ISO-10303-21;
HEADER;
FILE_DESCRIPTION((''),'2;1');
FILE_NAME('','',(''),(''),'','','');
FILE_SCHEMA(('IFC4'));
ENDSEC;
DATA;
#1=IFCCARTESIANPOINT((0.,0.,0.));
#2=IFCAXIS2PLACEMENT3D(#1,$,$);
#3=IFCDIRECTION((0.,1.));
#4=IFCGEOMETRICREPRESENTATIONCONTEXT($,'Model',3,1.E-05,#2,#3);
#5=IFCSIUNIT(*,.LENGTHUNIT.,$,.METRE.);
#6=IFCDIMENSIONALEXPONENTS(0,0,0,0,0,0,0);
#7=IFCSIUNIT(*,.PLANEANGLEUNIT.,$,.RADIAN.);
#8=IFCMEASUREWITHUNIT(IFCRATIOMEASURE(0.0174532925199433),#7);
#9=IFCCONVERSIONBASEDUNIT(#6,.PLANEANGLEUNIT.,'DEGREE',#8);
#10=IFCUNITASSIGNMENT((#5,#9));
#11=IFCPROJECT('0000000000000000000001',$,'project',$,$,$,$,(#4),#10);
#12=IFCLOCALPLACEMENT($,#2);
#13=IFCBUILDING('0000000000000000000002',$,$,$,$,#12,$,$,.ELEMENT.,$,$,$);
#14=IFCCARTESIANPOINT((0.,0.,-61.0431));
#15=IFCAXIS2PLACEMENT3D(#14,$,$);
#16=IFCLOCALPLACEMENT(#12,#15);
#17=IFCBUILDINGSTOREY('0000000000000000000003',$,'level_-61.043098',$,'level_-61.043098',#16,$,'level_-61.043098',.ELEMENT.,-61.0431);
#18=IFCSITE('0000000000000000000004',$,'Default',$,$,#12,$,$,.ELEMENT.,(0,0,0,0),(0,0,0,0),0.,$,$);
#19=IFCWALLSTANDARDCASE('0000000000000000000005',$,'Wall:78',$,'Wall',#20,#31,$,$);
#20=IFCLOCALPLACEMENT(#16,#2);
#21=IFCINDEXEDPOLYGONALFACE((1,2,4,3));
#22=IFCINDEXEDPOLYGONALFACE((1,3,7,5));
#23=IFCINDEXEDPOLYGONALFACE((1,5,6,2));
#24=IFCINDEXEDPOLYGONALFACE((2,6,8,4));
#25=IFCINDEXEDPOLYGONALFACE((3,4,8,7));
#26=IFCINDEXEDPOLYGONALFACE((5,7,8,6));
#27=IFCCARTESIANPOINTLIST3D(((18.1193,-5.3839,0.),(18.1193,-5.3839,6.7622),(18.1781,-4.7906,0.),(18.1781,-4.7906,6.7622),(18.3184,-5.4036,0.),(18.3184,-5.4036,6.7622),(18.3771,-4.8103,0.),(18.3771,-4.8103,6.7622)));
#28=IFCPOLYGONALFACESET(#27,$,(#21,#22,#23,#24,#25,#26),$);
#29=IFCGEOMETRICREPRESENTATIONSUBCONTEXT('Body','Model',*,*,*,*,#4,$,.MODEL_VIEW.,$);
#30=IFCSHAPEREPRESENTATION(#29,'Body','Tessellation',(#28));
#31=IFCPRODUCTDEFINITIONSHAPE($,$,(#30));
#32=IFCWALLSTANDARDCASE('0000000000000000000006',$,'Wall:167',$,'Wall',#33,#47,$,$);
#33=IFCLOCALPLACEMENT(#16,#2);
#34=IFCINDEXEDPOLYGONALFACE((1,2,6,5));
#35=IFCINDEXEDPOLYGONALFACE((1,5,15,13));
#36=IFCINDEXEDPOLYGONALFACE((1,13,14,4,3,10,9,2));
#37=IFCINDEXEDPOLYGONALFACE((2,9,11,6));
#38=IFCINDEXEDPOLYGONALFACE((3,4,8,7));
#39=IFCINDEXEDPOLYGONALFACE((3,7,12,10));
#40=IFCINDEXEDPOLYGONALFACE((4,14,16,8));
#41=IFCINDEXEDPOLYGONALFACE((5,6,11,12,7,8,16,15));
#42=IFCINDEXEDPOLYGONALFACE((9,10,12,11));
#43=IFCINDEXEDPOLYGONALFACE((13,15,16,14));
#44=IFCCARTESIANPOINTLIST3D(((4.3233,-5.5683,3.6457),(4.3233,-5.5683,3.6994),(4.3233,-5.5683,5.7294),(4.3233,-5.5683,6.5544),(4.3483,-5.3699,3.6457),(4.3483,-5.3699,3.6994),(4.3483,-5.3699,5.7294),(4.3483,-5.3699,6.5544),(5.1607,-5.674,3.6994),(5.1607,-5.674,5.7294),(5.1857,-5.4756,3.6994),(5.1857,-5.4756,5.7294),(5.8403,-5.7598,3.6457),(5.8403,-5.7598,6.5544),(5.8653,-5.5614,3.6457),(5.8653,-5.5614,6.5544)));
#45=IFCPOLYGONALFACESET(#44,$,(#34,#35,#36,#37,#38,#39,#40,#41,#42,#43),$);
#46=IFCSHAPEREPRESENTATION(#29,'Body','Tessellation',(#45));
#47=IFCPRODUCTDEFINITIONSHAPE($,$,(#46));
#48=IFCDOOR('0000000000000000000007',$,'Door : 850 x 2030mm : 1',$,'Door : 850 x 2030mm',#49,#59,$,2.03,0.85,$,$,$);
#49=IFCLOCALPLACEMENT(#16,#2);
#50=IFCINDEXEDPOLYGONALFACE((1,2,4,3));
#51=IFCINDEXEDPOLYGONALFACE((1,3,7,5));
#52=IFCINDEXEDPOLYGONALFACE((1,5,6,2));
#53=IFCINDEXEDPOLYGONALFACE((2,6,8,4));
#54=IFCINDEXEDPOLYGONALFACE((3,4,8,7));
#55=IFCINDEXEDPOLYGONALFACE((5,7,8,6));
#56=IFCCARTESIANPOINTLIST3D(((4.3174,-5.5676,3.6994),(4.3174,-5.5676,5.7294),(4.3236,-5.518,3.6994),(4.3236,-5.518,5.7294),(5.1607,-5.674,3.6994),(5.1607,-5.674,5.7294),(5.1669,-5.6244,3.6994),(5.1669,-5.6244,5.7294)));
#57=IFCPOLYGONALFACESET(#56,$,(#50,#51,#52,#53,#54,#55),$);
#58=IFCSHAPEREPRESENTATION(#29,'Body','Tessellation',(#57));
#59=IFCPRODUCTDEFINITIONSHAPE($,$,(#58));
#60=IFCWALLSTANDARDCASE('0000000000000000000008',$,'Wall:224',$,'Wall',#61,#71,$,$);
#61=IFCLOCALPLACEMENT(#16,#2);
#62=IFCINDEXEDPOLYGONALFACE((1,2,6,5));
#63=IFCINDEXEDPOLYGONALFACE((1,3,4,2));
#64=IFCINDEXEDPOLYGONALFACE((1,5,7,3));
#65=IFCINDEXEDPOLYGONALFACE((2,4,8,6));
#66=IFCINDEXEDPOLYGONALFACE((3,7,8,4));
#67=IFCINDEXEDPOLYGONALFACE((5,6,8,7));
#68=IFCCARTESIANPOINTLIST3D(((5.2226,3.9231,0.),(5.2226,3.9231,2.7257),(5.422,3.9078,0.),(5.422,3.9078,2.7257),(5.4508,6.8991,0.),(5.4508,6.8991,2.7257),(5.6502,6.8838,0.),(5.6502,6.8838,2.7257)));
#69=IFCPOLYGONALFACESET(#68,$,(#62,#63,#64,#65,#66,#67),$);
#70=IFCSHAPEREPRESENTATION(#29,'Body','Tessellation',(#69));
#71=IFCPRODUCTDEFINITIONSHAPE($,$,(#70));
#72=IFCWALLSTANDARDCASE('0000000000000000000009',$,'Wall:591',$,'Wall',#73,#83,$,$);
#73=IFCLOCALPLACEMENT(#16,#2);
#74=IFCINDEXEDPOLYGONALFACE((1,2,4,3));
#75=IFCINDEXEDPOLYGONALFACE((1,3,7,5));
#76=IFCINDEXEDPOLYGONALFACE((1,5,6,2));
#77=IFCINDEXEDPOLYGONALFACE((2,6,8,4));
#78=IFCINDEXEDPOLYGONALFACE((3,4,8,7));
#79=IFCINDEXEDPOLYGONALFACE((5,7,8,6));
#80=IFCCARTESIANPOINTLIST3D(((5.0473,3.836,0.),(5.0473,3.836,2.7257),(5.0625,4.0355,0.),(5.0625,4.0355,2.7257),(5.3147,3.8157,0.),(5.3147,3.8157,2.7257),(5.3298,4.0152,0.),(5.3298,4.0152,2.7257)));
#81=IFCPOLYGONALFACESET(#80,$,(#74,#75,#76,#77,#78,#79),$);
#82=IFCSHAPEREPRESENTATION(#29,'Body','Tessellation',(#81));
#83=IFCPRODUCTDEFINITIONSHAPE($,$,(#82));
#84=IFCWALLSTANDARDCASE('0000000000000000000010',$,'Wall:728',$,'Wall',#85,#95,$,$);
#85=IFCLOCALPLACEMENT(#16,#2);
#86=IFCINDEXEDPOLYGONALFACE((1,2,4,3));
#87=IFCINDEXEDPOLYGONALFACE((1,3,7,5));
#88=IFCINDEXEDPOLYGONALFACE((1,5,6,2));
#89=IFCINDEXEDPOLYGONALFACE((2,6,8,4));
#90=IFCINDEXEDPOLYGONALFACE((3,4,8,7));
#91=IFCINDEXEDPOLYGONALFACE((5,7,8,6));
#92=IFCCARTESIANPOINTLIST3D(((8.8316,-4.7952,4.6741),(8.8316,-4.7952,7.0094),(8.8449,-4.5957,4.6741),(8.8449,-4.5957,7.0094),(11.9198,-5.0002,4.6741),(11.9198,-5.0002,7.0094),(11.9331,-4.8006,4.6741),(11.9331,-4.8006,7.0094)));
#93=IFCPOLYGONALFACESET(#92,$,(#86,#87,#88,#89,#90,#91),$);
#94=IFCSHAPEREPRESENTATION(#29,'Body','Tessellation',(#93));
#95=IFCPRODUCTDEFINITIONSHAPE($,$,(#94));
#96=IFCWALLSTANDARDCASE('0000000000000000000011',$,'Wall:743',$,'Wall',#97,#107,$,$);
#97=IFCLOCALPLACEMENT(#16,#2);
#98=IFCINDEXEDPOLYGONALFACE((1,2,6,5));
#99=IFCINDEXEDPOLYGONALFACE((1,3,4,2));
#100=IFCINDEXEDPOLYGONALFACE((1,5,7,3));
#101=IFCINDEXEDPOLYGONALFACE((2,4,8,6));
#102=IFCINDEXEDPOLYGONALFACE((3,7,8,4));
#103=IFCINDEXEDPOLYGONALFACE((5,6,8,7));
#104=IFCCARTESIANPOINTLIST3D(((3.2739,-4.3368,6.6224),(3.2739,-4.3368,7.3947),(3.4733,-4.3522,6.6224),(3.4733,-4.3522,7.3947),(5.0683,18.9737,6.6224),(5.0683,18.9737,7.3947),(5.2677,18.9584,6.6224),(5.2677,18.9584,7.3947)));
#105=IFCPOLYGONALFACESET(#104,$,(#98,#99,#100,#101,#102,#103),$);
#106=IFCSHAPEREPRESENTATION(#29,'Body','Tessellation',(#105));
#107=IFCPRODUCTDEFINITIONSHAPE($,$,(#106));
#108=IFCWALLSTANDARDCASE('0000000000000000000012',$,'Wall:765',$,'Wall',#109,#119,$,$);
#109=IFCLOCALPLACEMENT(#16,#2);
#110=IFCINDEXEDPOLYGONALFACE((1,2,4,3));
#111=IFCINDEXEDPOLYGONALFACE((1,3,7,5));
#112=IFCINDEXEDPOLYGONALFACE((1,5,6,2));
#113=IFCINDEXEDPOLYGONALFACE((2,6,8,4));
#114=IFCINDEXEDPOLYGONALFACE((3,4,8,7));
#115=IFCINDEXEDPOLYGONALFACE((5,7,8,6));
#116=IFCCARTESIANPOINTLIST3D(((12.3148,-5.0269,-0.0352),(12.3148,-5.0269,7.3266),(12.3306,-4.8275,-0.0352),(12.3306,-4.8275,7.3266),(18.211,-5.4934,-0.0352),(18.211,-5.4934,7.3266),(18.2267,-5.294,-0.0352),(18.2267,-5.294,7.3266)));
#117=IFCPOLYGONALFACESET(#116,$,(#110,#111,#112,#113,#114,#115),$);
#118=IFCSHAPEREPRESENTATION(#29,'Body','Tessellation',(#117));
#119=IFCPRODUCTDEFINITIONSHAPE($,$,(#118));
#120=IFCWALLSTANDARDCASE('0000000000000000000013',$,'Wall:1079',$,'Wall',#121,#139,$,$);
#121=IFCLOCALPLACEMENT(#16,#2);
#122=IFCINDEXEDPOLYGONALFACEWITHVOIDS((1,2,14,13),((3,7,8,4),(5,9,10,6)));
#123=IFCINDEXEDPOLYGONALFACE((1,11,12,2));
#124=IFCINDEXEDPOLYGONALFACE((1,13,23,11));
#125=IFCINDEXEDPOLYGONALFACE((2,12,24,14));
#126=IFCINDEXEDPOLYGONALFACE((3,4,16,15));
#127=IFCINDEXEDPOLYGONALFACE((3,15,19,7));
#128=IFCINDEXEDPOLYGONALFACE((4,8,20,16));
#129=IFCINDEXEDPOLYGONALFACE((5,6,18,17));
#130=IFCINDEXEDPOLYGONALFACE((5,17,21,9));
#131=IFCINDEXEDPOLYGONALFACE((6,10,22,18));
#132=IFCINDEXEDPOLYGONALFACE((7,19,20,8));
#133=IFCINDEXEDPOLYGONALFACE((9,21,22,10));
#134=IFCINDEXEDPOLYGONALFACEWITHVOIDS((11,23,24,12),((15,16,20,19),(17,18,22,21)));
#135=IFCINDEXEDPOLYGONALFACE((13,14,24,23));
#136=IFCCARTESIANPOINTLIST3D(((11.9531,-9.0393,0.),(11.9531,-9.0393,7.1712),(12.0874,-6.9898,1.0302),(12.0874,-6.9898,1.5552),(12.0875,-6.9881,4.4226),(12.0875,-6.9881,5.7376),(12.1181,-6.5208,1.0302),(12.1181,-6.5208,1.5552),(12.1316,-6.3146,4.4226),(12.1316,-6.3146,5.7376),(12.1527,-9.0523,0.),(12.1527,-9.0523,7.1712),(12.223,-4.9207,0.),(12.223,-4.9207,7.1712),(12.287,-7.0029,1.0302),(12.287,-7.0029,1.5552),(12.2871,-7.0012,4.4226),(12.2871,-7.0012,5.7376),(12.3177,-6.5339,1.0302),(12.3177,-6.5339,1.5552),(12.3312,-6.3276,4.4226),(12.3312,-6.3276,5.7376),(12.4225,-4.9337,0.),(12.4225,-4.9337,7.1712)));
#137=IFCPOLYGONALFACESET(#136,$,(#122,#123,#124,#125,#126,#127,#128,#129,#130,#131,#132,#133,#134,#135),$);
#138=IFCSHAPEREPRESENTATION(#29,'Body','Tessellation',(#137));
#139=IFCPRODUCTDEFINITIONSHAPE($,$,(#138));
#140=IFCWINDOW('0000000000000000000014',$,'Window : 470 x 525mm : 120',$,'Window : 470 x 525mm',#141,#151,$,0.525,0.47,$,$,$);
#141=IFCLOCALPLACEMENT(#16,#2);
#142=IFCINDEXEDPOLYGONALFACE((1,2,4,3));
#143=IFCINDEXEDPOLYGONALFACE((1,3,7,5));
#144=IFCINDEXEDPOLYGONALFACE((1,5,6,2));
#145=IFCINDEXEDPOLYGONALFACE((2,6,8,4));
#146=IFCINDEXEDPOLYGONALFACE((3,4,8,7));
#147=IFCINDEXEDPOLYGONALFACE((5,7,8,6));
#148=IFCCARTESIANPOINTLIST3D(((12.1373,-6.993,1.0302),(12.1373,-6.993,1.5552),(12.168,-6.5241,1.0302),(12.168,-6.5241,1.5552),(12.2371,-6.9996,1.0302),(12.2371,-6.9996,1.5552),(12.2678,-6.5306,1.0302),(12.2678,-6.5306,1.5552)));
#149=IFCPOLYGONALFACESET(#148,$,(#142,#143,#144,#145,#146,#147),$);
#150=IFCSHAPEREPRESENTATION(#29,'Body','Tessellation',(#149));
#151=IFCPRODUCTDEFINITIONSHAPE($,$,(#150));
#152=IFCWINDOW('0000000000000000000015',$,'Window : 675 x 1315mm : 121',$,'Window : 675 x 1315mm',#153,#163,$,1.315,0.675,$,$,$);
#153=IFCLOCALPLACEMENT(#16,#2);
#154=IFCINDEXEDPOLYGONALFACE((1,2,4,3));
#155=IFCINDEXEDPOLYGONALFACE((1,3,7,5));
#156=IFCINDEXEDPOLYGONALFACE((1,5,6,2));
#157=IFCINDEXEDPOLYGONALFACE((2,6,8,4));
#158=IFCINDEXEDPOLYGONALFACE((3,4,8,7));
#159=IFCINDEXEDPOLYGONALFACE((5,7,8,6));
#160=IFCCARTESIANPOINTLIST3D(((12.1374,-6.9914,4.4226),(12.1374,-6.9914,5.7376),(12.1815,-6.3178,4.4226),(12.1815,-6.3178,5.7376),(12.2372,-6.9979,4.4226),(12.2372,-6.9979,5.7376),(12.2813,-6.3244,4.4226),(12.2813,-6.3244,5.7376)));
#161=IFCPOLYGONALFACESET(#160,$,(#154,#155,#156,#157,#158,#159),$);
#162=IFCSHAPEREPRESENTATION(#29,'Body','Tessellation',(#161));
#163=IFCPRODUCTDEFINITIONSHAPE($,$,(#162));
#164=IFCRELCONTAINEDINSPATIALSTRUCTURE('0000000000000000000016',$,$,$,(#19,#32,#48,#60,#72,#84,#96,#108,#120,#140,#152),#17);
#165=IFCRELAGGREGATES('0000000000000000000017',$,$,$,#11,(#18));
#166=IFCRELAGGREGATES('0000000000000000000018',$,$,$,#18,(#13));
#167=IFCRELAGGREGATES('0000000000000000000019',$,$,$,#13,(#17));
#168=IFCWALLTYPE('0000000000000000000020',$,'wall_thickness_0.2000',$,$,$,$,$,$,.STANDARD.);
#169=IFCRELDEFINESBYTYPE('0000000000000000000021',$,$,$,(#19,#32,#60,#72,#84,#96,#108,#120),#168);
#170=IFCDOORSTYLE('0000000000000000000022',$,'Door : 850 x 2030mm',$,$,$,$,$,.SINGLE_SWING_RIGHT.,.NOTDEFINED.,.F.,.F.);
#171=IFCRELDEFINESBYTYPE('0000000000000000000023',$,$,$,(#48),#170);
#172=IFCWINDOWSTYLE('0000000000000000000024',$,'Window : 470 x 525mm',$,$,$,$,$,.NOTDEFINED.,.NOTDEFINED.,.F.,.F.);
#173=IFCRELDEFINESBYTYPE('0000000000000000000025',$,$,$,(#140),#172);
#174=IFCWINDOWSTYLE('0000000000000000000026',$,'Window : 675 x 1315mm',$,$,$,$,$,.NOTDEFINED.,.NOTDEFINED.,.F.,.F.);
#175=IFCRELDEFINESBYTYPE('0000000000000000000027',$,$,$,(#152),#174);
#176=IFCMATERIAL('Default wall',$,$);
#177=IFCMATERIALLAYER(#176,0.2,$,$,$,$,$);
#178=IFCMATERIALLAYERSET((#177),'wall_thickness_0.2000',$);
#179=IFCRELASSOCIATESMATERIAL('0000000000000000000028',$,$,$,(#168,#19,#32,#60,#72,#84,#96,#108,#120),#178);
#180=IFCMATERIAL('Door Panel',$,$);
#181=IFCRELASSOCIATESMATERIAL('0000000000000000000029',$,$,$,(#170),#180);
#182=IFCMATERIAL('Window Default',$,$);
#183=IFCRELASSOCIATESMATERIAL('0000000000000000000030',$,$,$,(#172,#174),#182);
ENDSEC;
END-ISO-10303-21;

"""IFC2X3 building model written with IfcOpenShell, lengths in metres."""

from ifc_helpers import new_model, entity, si_unit, converted_unit, direction, frame, frame_2d, origin, origin_2d_with_axis, place, context, subcontext, project, spatial, polyline, rectangle, outline, extrude, source, transform, mapped, material, layer, layer_set, layer_usage, type_object, type_shapes, element, fill, save


model = new_model("IFC2X3")

# Units and contexts
model_context = context("Model", 3, precision=1e-05, world=origin(), true_north=direction((0.0, 1.0)))
body_context = subcontext(model_context, "Body", "Model", "MODEL_VIEW")
ifc_project = project(units=[si_unit("LENGTHUNIT", "METRE"), converted_unit("PLANEANGLEUNIT", "DEGREE", entity("IfcRatioMeasure", 0.0174532925199433), si_unit("PLANEANGLEUNIT", "RADIAN"), dimensions=[0, 0, 0, 0, 0, 0, 0])], contexts=[model_context])

# Site, building, storey
placement_1 = place(None, origin())
site = spatial("IfcSite", under=ifc_project, at=placement_1, Name="Default", CompositionType="ELEMENT", RefLatitude=(0, 0, 0, 0), RefLongitude=(0, 0, 0, 0), RefElevation=0.0)
building = spatial("IfcBuilding", under=site, at=placement_1, CompositionType="ELEMENT")
storey_placement = place(placement_1, frame((0.0, 0.0, -61.0431)))
storey = spatial("IfcBuildingStorey", under=building, at=storey_placement, Name="level_-61.043098", ObjectType="level_-61.043098", LongName="level_-61.043098", CompositionType="ELEMENT", Elevation=-61.0431)

# Wall
ifc_material_1 = material(Name="Default wall")
ifc_layer = layer(ifc_material_1, 0.2)
ifc_layer_set = layer_set([ifc_layer], Name="wall_thickness_0.2000")
ifc_layer_usage = layer_usage(ifc_layer_set, "AXIS2", "POSITIVE", -0.1)
wall_type = type_object("IfcWallType", Name="wall_thickness_0.2000", PredefinedType="STANDARD", material=ifc_layer_set)
wall_1_placement = place(storey_placement, frame((18.2189, -5.3937, 0.0), z_axis=(0.0, 0.0, 1.0), x_axis=(0.098503, 0.995137, 0.0)))
element("IfcWallStandardCase", 1, at=wall_1_placement, inside=storey, type_object=wall_type, material=ifc_layer_usage, Name="Wall:78", ObjectType="Wall", context=body_context, shape_type="SweptSolid", body=[
    extrude(outline(polyline([(0.5961, -0.1), (0.5961, 0.1), (0.0, 0.1), (0.0, -0.1), (0.5961, -0.1)])), origin(), (0.0, 0.0, 1.0), 6.7622),
])

# Wall, opening, door
placement_2 = place(placement_1, frame((0.0, 0.0, -57.3974)))
wall_2_placement = place(placement_2, frame((5.8528, -5.6606, 0.0), z_axis=(0.0, 0.0, 1.0), x_axis=(-0.992132, 0.125199, 0.0)))
wall_2 = element("IfcWallStandardCase", 2, at=wall_2_placement, inside=storey, type_object=wall_type, material=ifc_layer_usage, Name="Wall:167", ObjectType="Wall", context=body_context, shape_type="SweptSolid", body=[
    extrude(outline(polyline([(1.529, -0.1), (1.529, 0.1), (0.0, 0.1), (0.0, -0.1), (1.529, -0.1)])), origin(), (0.0, 0.0, 1.0), 2.9087),
])
opening_1_placement = place(wall_2_placement, frame((0.685, -0.1, 0.0537)))
opening_1 = element("IfcOpeningElement", 3, at=opening_1_placement, cuts=wall_2, ObjectType="Opening", context=body_context, shape_type="SweptSolid", body=[
    extrude(rectangle(XDim=0.85, YDim=2.03, at=frame_2d((1.015, 0.425), x_axis=(0.0, 1.0))), frame((0.0, 0.0, 0.0), z_axis=(0.0, 1.0, 0.0), x_axis=(0.0, 0.0, 1.0)), (0.0, 0.0, 1.0), 0.2),
])
ifc_material_2 = material(Name="Door Panel")
door_style = type_object("IfcDoorStyle", Name="Door : 850 x 2030mm", ConstructionType="NOTDEFINED", OperationType="SINGLE_SWING_RIGHT", ParameterTakesPrecedence=False, Sizeable=False, material=ifc_material_2)
shared_shape_1 = source(origin(), body_context, "Body", "SweptSolid", [
    extrude(rectangle(XDim=0.05, YDim=0.85, at=origin_2d_with_axis()), frame((0.425, 0.175, 0.0), z_axis=(0.0, 0.0, 1.0), x_axis=(0.0, 1.0, 0.0)), (0.0, 0.0, 1.0), 2.03),
])
type_shapes(door_style, [shared_shape_1])
door_placement = place(opening_1_placement, origin())
door = element("IfcDoor", 4, at=door_placement, inside=storey, type_object=door_style, Name="Door : 850 x 2030mm : 1", ObjectType="Door : 850 x 2030mm", OverallHeight=2.03, OverallWidth=0.85, context=body_context, shape_type="MappedRepresentation", body=[
    mapped(shared_shape_1, transform((0.0, 0.0, 0.0), scale=1.0)),
])
fill(opening_1, door)

# Walls
wall_3_placement = place(storey_placement, frame((5.5505, 6.8915, 0.0), z_axis=(0.0, 0.0, 1.0), x_axis=(-0.076474, -0.997072, 0.0)))
element("IfcWallStandardCase", 5, at=wall_3_placement, inside=storey, type_object=wall_type, material=ifc_layer_usage, Name="Wall:224", ObjectType="Wall", context=body_context, shape_type="SweptSolid", body=[
    extrude(outline(polyline([(2.9847, -0.1), (2.9847, 0.1), (0.0, 0.1), (0.0, -0.1), (2.9847, -0.1)])), origin(), (0.0, 0.0, 1.0), 2.7257),
])
wall_4_placement = place(storey_placement, frame((5.3223, 3.9154, 0.0), z_axis=(0.0, 0.0, 1.0), x_axis=(-0.997132, 0.075687, 0.0)))
element("IfcWallStandardCase", 6, at=wall_4_placement, inside=storey, type_object=wall_type, material=ifc_layer_usage, Name="Wall:591", ObjectType="Wall", context=body_context, shape_type="SweptSolid", body=[
    extrude(outline(polyline([(0.2681, -0.1), (0.2681, 0.1), (0.0, 0.1), (0.0, -0.1), (0.2681, -0.1)])), origin(), (0.0, 0.0, 1.0), 2.7257),
])
placement_3 = place(placement_1, frame((0.0, 0.0, -56.369)))
wall_5_placement = place(placement_3, frame((8.8382, -4.6955, 0.0), z_axis=(0.0, 0.0, 1.0), x_axis=(0.997805, -0.066216, 0.0)))
element("IfcWallStandardCase", 7, at=wall_5_placement, inside=storey, type_object=wall_type, material=ifc_layer_usage, Name="Wall:728", ObjectType="Wall", context=body_context, shape_type="SweptSolid", body=[
    extrude(outline(polyline([(3.095, -0.1), (3.095, 0.1), (0.0, 0.1), (0.0, -0.1), (3.095, -0.1)])), origin(), (0.0, 0.0, 1.0), 2.3352),
])
placement_4 = place(placement_1, frame((0.0, 0.0, -54.4207)))
wall_6_placement = place(placement_4, frame((3.3736, -4.3445, 0.0), z_axis=(0.0, 0.0, 1.0), x_axis=(0.07675, 0.99705, 0.0)))
element("IfcWallStandardCase", 8, at=wall_6_placement, inside=storey, type_object=wall_type, material=ifc_layer_usage, Name="Wall:743", ObjectType="Wall", context=body_context, shape_type="SweptSolid", body=[
    extrude(outline(polyline([(23.3795, -0.1), (23.3795, 0.1), (0.0, 0.1), (0.0, -0.1), (23.3795, -0.1)])), origin(), (0.0, 0.0, 1.0), 0.7723),
])
placement_5 = place(placement_1, frame((0.0, 0.0, -61.0783)))
wall_7_placement = place(placement_5, frame((18.2189, -5.3937, 0.0), z_axis=(0.0, 0.0, 1.0), x_axis=(-0.996885, 0.078875, 0.0)))
element("IfcWallStandardCase", 9, at=wall_7_placement, inside=storey, type_object=wall_type, material=ifc_layer_usage, Name="Wall:765", ObjectType="Wall", context=body_context, shape_type="SweptSolid", body=[
    extrude(outline(polyline([(5.9145, -0.1), (5.9145, 0.1), (0.0, 0.1), (0.0, -0.1), (5.9145, -0.1)])), origin(), (0.0, 0.0, 1.0), 7.3618),
])

# Wall, openings, windows
wall_8_placement = place(storey_placement, frame((12.3227, -4.9272, 0.0), z_axis=(0.0, 0.0, 1.0), x_axis=(-0.065369, -0.997861, 0.0)))
wall_8 = element("IfcWallStandardCase", 10, at=wall_8_placement, inside=storey, type_object=wall_type, material=ifc_layer_usage, Name="Wall:1079", ObjectType="Wall", context=body_context, shape_type="SweptSolid", body=[
    extrude(outline(polyline([(4.1274, -0.1), (4.1274, 0.1), (0.0, 0.1), (0.0, -0.1), (4.1274, -0.1)])), origin(), (0.0, 0.0, 1.0), 7.1712),
])
opening_2_placement = place(wall_8_placement, frame((1.6035, -0.1, 1.0302)))
opening_2 = element("IfcOpeningElement", 11, at=opening_2_placement, cuts=wall_8, ObjectType="Opening", context=body_context, shape_type="SweptSolid", body=[
    extrude(rectangle(XDim=0.47, YDim=0.525, at=frame_2d((0.2625, 0.235), x_axis=(0.0, 1.0))), frame((0.0, 0.0, 0.0), z_axis=(0.0, 1.0, 0.0), x_axis=(0.0, 0.0, 1.0)), (0.0, 0.0, 1.0), 0.2),
])
opening_3_placement = place(wall_8_placement, frame((1.3969, -0.1, 4.4226)))
opening_3 = element("IfcOpeningElement", 12, at=opening_3_placement, cuts=wall_8, ObjectType="Opening", context=body_context, shape_type="SweptSolid", body=[
    extrude(rectangle(XDim=0.675, YDim=1.315, at=frame_2d((0.6575, 0.3375), x_axis=(0.0, 1.0))), frame((0.0, 0.0, 0.0), z_axis=(0.0, 1.0, 0.0), x_axis=(0.0, 0.0, 1.0)), (0.0, 0.0, 1.0), 0.2),
])
ifc_material_3 = material(Name="Window Default")
window_style_1 = type_object("IfcWindowStyle", Name="Window : 470 x 525mm", ConstructionType="NOTDEFINED", OperationType="NOTDEFINED", ParameterTakesPrecedence=False, Sizeable=False, material=ifc_material_3)
shared_shape_2 = source(origin(), body_context, "Body", "SweptSolid", [
    extrude(rectangle(XDim=0.1, YDim=0.47, at=origin_2d_with_axis()), frame((0.235, 0.1, 0.0), z_axis=(0.0, 0.0, 1.0), x_axis=(0.0, 1.0, 0.0)), (0.0, 0.0, 1.0), 0.525),
])
type_shapes(window_style_1, [shared_shape_2])
window_1_placement = place(opening_2_placement, origin())
window_1 = element("IfcWindow", 13, at=window_1_placement, inside=storey, type_object=window_style_1, Name="Window : 470 x 525mm : 120", ObjectType="Window : 470 x 525mm", OverallHeight=0.525, OverallWidth=0.47, context=body_context, shape_type="MappedRepresentation", body=[
    mapped(shared_shape_2, transform((0.0, 0.0, 0.0), scale=1.0)),
])
fill(opening_2, window_1)
window_style_2 = type_object("IfcWindowStyle", Name="Window : 675 x 1315mm", ConstructionType="NOTDEFINED", OperationType="NOTDEFINED", ParameterTakesPrecedence=False, Sizeable=False, material=ifc_material_3)
shared_shape_3 = source(origin(), body_context, "Body", "SweptSolid", [
    extrude(rectangle(XDim=0.1, YDim=0.675, at=origin_2d_with_axis()), frame((0.3375, 0.1, 0.0), z_axis=(0.0, 0.0, 1.0), x_axis=(0.0, 1.0, 0.0)), (0.0, 0.0, 1.0), 1.315),
])
type_shapes(window_style_2, [shared_shape_3])
window_2_placement = place(opening_3_placement, origin())
window_2 = element("IfcWindow", 14, at=window_2_placement, inside=storey, type_object=window_style_2, Name="Window : 675 x 1315mm : 121", ObjectType="Window : 675 x 1315mm", OverallHeight=1.315, OverallWidth=0.675, context=body_context, shape_type="MappedRepresentation", body=[
    mapped(shared_shape_3, transform((0.0, 0.0, 0.0), scale=1.0)),
])
fill(opening_3, window_2)

save(model, "model.ifc")
